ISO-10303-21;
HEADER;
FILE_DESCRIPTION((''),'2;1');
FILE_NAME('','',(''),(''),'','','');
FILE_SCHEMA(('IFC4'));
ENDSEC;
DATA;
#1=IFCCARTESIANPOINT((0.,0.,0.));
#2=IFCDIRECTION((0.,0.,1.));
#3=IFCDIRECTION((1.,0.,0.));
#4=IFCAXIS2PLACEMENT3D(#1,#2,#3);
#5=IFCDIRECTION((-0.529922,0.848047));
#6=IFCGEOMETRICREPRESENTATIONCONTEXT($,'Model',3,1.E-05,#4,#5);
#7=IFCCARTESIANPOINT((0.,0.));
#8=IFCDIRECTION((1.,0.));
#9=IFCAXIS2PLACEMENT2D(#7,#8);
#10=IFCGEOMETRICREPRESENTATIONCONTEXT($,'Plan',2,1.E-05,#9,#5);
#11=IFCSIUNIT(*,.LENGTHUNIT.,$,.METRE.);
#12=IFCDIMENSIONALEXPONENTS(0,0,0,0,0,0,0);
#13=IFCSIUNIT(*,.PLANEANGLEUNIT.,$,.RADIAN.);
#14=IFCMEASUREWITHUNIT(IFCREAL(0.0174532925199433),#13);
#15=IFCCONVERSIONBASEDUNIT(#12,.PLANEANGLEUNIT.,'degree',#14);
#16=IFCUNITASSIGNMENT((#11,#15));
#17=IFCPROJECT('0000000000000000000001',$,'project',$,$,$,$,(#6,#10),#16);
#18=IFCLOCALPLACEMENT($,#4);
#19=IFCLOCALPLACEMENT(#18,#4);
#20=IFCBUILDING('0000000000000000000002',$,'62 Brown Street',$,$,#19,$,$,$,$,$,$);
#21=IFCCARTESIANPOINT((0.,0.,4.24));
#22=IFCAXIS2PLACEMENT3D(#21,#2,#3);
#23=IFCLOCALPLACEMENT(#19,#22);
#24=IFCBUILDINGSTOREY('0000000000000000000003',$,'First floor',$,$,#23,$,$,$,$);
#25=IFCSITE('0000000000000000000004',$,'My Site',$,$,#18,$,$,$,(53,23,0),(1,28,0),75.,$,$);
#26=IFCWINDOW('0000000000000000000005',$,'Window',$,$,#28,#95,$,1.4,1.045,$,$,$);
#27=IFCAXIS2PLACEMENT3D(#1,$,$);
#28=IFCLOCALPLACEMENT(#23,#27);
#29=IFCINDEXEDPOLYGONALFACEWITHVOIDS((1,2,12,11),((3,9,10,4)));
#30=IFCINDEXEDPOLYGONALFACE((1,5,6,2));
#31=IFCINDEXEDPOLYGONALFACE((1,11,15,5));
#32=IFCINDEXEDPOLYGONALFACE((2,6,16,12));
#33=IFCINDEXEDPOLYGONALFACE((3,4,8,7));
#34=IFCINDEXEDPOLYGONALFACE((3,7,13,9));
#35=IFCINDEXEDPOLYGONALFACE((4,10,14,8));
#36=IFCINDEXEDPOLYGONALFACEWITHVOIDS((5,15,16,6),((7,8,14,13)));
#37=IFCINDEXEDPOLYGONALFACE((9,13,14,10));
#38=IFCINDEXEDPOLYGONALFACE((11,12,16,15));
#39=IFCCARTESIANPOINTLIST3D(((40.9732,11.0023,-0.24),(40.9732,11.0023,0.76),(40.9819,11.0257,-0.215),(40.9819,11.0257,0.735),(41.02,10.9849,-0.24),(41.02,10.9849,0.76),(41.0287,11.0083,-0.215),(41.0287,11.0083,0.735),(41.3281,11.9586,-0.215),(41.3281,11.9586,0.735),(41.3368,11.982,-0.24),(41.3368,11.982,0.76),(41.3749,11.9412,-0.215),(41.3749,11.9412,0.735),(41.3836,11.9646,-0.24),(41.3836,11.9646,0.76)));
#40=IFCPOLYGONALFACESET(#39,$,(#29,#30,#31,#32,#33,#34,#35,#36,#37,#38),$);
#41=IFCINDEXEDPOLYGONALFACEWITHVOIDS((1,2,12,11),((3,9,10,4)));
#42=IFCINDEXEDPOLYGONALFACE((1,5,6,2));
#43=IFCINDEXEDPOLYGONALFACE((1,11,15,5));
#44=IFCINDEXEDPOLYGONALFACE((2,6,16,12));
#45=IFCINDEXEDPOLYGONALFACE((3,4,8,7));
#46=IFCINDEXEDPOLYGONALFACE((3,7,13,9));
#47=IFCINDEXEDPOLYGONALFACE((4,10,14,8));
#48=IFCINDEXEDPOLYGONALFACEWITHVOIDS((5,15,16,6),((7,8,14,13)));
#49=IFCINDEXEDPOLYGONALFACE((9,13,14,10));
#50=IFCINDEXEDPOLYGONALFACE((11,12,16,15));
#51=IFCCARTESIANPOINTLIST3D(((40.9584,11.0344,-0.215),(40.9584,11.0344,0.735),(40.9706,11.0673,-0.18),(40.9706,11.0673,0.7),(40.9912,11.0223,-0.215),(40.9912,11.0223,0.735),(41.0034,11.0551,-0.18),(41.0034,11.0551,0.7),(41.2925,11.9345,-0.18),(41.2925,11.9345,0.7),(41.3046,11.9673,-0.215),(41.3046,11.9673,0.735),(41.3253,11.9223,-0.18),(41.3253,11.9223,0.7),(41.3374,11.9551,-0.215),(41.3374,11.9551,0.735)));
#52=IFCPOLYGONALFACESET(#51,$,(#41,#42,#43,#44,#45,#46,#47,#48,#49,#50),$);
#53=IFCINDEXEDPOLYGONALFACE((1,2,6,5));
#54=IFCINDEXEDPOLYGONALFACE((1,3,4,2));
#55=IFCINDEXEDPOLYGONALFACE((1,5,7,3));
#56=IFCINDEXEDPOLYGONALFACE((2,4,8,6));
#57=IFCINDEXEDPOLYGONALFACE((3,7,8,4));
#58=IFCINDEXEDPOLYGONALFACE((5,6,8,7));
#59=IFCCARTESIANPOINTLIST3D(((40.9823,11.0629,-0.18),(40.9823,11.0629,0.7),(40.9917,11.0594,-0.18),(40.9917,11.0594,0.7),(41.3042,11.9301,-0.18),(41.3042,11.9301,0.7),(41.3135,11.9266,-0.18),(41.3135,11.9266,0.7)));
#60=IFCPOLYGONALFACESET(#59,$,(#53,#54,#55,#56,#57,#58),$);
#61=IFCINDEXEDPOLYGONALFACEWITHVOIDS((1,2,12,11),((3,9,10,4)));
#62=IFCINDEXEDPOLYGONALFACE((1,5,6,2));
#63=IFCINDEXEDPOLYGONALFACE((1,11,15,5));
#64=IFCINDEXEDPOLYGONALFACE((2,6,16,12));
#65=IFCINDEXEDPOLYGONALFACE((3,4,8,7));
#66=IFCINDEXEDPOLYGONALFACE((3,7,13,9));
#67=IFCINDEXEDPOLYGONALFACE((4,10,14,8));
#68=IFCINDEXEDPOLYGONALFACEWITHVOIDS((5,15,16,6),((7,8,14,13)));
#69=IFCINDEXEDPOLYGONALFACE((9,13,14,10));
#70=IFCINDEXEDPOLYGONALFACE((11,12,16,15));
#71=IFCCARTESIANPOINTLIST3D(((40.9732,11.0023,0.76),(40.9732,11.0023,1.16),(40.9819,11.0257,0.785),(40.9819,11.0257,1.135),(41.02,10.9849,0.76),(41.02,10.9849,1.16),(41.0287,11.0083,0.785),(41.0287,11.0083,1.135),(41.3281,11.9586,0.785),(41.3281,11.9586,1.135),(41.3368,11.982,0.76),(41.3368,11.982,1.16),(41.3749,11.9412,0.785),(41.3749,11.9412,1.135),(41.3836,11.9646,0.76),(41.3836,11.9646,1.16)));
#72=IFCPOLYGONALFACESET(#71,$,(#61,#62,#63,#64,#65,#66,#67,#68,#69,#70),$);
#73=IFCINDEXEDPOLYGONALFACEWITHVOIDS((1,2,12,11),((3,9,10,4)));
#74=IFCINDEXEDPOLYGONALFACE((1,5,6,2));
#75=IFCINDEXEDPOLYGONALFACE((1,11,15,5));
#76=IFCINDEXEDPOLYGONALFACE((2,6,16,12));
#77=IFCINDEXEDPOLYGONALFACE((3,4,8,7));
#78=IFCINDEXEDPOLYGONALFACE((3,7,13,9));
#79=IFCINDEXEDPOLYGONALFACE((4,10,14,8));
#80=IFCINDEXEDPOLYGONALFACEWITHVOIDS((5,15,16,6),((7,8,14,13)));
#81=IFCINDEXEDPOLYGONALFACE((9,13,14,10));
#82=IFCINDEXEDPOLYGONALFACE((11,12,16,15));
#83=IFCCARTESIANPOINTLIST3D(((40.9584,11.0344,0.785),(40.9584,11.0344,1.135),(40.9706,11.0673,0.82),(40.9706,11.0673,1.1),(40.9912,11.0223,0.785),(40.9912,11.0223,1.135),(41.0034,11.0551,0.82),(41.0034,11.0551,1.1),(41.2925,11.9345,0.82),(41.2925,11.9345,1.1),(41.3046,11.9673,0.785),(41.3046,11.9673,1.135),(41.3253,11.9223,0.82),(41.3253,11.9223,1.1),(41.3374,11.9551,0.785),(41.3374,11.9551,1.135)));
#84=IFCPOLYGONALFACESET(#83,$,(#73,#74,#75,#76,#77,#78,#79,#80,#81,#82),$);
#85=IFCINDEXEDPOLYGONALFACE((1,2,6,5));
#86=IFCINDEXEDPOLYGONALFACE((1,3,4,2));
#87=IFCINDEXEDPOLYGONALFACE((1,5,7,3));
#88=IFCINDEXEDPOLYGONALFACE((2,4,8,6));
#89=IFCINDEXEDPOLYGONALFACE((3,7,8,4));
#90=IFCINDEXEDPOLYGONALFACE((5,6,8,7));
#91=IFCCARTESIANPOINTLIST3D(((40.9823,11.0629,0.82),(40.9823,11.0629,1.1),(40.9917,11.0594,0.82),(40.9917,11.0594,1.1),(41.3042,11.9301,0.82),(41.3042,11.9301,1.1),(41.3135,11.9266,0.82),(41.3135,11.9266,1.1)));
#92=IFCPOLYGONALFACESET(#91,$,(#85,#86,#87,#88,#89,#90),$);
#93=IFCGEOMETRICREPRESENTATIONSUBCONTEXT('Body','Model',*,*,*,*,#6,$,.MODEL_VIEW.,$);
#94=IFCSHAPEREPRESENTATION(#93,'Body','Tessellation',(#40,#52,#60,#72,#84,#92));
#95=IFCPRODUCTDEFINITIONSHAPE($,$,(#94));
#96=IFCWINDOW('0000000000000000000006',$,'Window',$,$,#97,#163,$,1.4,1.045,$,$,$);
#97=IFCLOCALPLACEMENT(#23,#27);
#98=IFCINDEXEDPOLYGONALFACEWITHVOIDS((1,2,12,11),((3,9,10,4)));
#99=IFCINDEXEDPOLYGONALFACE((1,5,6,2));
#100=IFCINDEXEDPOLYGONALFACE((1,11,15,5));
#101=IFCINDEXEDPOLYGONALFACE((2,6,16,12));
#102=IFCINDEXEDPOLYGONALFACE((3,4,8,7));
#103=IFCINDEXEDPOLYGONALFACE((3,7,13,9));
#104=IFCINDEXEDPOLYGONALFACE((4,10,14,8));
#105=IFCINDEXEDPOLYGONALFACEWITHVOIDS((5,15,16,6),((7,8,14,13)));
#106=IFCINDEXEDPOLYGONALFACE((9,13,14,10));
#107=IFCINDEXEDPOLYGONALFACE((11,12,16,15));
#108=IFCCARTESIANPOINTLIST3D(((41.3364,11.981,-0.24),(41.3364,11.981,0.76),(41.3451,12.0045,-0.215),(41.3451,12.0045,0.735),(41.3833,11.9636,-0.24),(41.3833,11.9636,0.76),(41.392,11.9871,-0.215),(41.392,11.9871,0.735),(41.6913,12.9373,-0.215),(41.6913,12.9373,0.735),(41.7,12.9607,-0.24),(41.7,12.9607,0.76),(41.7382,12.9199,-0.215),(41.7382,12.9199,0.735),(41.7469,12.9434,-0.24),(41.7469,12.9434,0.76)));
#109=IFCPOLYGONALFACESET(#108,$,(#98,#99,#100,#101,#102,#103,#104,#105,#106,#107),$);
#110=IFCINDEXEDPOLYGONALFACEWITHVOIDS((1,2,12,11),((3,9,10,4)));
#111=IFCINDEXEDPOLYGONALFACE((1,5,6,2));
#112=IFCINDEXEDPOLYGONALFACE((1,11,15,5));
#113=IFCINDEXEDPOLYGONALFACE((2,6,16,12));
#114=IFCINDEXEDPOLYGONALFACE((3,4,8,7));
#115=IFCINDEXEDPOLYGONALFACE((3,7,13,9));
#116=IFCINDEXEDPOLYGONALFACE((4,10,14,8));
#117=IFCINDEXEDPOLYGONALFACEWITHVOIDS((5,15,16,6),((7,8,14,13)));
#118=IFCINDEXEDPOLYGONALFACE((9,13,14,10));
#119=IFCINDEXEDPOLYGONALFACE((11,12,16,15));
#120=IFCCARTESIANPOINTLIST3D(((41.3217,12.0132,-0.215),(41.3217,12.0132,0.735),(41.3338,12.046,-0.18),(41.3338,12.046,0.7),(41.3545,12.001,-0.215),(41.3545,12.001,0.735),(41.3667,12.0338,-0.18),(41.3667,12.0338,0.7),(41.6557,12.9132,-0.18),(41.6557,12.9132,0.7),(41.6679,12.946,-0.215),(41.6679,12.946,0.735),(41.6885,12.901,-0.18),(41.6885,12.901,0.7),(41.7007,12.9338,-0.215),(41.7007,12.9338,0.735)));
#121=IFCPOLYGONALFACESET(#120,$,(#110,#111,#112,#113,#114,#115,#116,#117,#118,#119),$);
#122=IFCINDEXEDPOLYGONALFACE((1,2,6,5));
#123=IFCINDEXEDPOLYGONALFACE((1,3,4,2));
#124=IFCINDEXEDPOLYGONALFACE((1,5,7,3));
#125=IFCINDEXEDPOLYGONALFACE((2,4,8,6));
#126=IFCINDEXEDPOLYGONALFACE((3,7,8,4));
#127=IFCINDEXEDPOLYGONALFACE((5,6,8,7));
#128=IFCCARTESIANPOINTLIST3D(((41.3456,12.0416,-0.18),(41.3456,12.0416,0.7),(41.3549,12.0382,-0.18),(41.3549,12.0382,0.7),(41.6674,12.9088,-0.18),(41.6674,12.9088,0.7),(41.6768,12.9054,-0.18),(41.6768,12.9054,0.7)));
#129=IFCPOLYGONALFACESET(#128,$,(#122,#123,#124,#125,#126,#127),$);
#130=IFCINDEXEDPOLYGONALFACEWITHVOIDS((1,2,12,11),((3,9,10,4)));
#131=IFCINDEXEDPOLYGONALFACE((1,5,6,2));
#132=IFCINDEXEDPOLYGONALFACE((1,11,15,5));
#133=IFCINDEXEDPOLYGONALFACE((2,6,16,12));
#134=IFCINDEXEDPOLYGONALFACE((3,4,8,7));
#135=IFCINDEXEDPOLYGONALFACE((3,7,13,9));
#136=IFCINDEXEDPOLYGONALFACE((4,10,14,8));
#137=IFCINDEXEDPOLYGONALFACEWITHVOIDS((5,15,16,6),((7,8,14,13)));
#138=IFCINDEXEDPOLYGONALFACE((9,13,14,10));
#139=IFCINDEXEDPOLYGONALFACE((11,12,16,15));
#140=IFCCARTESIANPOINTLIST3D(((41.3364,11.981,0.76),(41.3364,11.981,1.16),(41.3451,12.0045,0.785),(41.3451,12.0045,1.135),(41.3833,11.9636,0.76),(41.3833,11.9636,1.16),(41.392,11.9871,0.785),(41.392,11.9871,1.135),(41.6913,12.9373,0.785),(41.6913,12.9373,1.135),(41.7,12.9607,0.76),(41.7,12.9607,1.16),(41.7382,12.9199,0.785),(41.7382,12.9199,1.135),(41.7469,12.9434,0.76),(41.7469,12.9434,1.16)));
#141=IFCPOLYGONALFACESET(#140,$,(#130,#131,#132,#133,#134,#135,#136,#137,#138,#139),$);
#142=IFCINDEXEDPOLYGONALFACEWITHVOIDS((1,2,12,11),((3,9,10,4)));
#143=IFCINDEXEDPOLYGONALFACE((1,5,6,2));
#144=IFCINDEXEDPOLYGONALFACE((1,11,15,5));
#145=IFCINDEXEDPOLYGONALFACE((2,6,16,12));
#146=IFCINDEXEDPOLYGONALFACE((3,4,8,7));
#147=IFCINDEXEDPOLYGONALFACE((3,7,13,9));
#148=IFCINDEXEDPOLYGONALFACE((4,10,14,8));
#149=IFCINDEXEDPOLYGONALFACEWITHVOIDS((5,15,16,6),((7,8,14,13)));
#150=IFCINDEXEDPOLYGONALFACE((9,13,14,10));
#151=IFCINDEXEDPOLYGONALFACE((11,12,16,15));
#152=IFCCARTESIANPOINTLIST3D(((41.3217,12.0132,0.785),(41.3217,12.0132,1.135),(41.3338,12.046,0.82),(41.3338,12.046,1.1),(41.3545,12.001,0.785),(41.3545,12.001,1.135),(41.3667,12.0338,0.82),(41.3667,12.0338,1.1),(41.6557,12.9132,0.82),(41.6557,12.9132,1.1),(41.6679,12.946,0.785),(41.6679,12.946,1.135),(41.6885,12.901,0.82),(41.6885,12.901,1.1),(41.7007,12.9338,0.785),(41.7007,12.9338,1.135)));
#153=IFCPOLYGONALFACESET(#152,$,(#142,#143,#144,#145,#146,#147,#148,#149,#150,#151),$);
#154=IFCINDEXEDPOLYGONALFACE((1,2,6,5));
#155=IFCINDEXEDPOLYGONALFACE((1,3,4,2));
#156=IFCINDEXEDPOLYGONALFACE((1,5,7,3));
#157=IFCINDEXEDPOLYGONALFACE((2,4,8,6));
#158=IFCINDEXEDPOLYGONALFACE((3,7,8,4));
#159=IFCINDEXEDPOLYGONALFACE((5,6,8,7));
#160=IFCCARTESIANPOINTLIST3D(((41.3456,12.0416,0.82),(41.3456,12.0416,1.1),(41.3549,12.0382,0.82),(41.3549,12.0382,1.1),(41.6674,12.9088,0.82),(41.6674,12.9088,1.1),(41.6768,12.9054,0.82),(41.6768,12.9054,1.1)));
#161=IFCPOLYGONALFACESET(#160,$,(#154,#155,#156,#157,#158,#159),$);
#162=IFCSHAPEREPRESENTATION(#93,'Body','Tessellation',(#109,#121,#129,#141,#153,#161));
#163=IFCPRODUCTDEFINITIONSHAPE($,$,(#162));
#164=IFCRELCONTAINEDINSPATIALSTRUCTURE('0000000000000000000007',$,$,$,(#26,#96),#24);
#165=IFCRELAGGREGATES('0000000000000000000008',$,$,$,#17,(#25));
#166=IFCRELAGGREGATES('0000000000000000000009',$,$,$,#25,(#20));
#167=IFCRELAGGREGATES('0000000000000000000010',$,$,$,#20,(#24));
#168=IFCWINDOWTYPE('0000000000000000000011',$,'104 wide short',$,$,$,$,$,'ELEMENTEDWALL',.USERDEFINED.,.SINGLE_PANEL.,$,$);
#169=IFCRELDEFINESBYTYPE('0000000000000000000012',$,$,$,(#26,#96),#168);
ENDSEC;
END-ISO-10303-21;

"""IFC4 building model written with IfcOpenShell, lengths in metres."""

from ifc_helpers import new_model, entity, si_unit, converted_unit, direction, frame, origin_with_axes, origin_2d_with_axis, place, context, subcontext, project, spatial, line, indexed_curve, outline, extrude, shape, source, transform, mapped, type_object, type_shapes, element, save


model = new_model("IFC4")

# Units and contexts
model_context = context("Model", 3, precision=1e-05, world=origin_with_axes(), true_north=direction((-0.529922, 0.848047)))
plan_context = context("Plan", 2, precision=1e-05, world=origin_2d_with_axis(), true_north=direction((-0.529922, 0.848047)))
body_context_1 = subcontext(model_context, "Body", "Model", "MODEL_VIEW")
body_context_2 = subcontext(plan_context, "Body", "Plan", "PLAN_VIEW")
ifc_project = project(units=[si_unit("LENGTHUNIT", "METRE"), converted_unit("PLANEANGLEUNIT", "degree", entity("IfcReal", 0.0174532925199433), si_unit("PLANEANGLEUNIT", "RADIAN"), dimensions=[0, 0, 0, 0, 0, 0, 0])], contexts=[model_context, plan_context])

# Site, building, storey
site_placement = place(None, origin_with_axes())
site = spatial("IfcSite", under=ifc_project, at=site_placement, Name="My Site", RefLatitude=(53, 23, 0), RefLongitude=(1, 28, 0), RefElevation=75.0)
building_placement = place(site_placement, origin_with_axes())
building = spatial("IfcBuilding", under=site, at=building_placement, Name="62 Brown Street")
storey_placement = place(building_placement, frame((0.0, 0.0, 4.24), z_axis=(0.0, 0.0, 1.0), x_axis=(1.0, 0.0, 0.0)))
storey = spatial("IfcBuildingStorey", under=building, at=storey_placement, Name="First floor")

# Shared definitions
window_type = type_object("IfcWindowType", Name="104 wide short", ElementType="ELEMENTEDWALL", PartitioningType="SINGLE_PANEL", PredefinedType="USERDEFINED")
shared_shape_1 = source(origin_with_axes(), body_context_1, "Body", "SweptSolid", [
    extrude(outline(indexed_curve([(0.0, 0.0), (1.045, 0.0), (1.045, 1.0), (0.0, 1.0)], segments=[line(1, 2, 3, 4, 1)]), holes=[indexed_curve([(0.025, 0.025), (1.02, 0.025), (1.02, 0.975), (0.025, 0.975)], segments=[line(1, 2, 3, 4, 1)])]), frame((0.0, 0.15, 0.0), z_axis=(0.0, -1.0, 0.0), x_axis=(1.0, 0.0, 0.0)), (0.0, 0.0, -1.0), 0.05),
    extrude(outline(indexed_curve([(0.0, 0.0), (0.995, 0.0), (0.995, 0.95), (0.0, 0.95)], segments=[line(1, 2, 3, 4, 1)]), holes=[indexed_curve([(0.035, 0.035), (0.96, 0.035), (0.96, 0.915), (0.035, 0.915)], segments=[line(1, 2, 3, 4, 1)])]), frame((0.025, 0.19, 0.025), z_axis=(0.0, -1.0, 0.0), x_axis=(1.0, 0.0, 0.0)), (0.0, 0.0, -1.0), 0.035),
    extrude(outline(indexed_curve([(0.035, 0.035), (0.96, 0.035), (0.96, 0.915), (0.035, 0.915)], segments=[line(1, 2, 3, 4, 1)])), frame((0.025, 0.2025, 0.025), z_axis=(0.0, -1.0, 0.0), x_axis=(1.0, 0.0, 0.0)), (0.0, 0.0, -1.0), 0.01),
    extrude(outline(indexed_curve([(0.0, 0.0), (1.045, 0.0), (1.045, 0.4), (0.0, 0.4)], segments=[line(1, 2, 3, 4, 1)]), holes=[indexed_curve([(0.025, 0.025), (1.02, 0.025), (1.02, 0.375), (0.025, 0.375)], segments=[line(1, 2, 3, 4, 1)])]), frame((0.0, 0.15, 1.0), z_axis=(0.0, -1.0, 0.0), x_axis=(1.0, 0.0, 0.0)), (0.0, 0.0, -1.0), 0.05),
    extrude(outline(indexed_curve([(0.0, 0.0), (0.995, 0.0), (0.995, 0.35), (0.0, 0.35)], segments=[line(1, 2, 3, 4, 1)]), holes=[indexed_curve([(0.035, 0.035), (0.96, 0.035), (0.96, 0.315), (0.035, 0.315)], segments=[line(1, 2, 3, 4, 1)])]), frame((0.025, 0.19, 1.025), z_axis=(0.0, -1.0, 0.0), x_axis=(1.0, 0.0, 0.0)), (0.0, 0.0, -1.0), 0.035),
    extrude(outline(indexed_curve([(0.035, 0.035), (0.96, 0.035), (0.96, 0.315), (0.035, 0.315)], segments=[line(1, 2, 3, 4, 1)])), frame((0.025, 0.2025, 1.025), z_axis=(0.0, -1.0, 0.0), x_axis=(1.0, 0.0, 0.0)), (0.0, 0.0, -1.0), 0.01),
])
shared_shape_2 = source(origin_with_axes(), body_context_2, "Body", "Curve2D", [
    entity("IfcIndexedPolyCurve", entity("IfcCartesianPointList2D", [[0.025, 0.15], [1.02, 0.15]])),
    entity("IfcIndexedPolyCurve", entity("IfcCartesianPointList2D", [[0.0, 0.2], [0.025, 0.2], [0.025, 0.15], [0.0, 0.15]]), [entity("IfcLineIndex", [1, 2, 3, 4, 1])]),
    entity("IfcIndexedPolyCurve", entity("IfcCartesianPointList2D", [[1.045, 0.2], [1.02, 0.2], [1.02, 0.15], [1.045, 0.15]]), [entity("IfcLineIndex", [1, 2, 3, 4, 1])]),
    entity("IfcIndexedPolyCurve", entity("IfcCartesianPointList2D", [[0.025, 0.19], [0.06, 0.19], [0.06, 0.225], [0.025, 0.225]]), [entity("IfcLineIndex", [1, 2, 3, 4, 1])]),
    entity("IfcIndexedPolyCurve", entity("IfcCartesianPointList2D", [[1.02, 0.19], [0.985, 0.19], [0.985, 0.225], [1.02, 0.225]]), [entity("IfcLineIndex", [1, 2, 3, 4, 1])]),
    entity("IfcIndexedPolyCurve", entity("IfcCartesianPointList2D", [[0.06, 0.19], [0.985, 0.19]])),
    entity("IfcIndexedPolyCurve", entity("IfcCartesianPointList2D", [[0.06, 0.225], [0.985, 0.225]])),
    entity("IfcIndexedPolyCurve", entity("IfcCartesianPointList2D", [[0.06, 0.2075], [0.985, 0.2075]])),
])
type_shapes(window_type, [shared_shape_1, shared_shape_2])

# Windows
for number, where, z_axis, x_axis, name in (
    (1, (41.1607, 10.9327, -0.24), (0.0, 0.0, 1.0), (0.347944, 0.937515, 0.0), "Window"),
    (2, (41.5239, 11.9115, -0.24), (0.0, 0.0, 1.0), (0.347944, 0.937515, 0.0), "Window"),
):
    element("IfcWindow", number, at=place(storey_placement, frame(where, z_axis=z_axis, x_axis=x_axis)), inside=storey, type_object=window_type, Name=name, OverallHeight=1.4, OverallWidth=1.045, shapes=[
        shape(body_context_1, "Body", "MappedRepresentation", [mapped(shared_shape_1, transform((0.0, 0.0, 0.0), x_axis=(1.0, 0.0, 0.0), y_axis=(0.0, 1.0, 0.0), z_axis=(0.0, 0.0, 1.0), scale=1.0))]),
        shape(body_context_2, "Body", "MappedRepresentation", [mapped(shared_shape_2, transform((0.0, 0.0, 0.0), x_axis=(1.0, 0.0, 0.0), y_axis=(0.0, 1.0, 0.0), z_axis=(0.0, 0.0, 1.0), scale=1.0))]),
    ])

save(model, "model.ifc")
